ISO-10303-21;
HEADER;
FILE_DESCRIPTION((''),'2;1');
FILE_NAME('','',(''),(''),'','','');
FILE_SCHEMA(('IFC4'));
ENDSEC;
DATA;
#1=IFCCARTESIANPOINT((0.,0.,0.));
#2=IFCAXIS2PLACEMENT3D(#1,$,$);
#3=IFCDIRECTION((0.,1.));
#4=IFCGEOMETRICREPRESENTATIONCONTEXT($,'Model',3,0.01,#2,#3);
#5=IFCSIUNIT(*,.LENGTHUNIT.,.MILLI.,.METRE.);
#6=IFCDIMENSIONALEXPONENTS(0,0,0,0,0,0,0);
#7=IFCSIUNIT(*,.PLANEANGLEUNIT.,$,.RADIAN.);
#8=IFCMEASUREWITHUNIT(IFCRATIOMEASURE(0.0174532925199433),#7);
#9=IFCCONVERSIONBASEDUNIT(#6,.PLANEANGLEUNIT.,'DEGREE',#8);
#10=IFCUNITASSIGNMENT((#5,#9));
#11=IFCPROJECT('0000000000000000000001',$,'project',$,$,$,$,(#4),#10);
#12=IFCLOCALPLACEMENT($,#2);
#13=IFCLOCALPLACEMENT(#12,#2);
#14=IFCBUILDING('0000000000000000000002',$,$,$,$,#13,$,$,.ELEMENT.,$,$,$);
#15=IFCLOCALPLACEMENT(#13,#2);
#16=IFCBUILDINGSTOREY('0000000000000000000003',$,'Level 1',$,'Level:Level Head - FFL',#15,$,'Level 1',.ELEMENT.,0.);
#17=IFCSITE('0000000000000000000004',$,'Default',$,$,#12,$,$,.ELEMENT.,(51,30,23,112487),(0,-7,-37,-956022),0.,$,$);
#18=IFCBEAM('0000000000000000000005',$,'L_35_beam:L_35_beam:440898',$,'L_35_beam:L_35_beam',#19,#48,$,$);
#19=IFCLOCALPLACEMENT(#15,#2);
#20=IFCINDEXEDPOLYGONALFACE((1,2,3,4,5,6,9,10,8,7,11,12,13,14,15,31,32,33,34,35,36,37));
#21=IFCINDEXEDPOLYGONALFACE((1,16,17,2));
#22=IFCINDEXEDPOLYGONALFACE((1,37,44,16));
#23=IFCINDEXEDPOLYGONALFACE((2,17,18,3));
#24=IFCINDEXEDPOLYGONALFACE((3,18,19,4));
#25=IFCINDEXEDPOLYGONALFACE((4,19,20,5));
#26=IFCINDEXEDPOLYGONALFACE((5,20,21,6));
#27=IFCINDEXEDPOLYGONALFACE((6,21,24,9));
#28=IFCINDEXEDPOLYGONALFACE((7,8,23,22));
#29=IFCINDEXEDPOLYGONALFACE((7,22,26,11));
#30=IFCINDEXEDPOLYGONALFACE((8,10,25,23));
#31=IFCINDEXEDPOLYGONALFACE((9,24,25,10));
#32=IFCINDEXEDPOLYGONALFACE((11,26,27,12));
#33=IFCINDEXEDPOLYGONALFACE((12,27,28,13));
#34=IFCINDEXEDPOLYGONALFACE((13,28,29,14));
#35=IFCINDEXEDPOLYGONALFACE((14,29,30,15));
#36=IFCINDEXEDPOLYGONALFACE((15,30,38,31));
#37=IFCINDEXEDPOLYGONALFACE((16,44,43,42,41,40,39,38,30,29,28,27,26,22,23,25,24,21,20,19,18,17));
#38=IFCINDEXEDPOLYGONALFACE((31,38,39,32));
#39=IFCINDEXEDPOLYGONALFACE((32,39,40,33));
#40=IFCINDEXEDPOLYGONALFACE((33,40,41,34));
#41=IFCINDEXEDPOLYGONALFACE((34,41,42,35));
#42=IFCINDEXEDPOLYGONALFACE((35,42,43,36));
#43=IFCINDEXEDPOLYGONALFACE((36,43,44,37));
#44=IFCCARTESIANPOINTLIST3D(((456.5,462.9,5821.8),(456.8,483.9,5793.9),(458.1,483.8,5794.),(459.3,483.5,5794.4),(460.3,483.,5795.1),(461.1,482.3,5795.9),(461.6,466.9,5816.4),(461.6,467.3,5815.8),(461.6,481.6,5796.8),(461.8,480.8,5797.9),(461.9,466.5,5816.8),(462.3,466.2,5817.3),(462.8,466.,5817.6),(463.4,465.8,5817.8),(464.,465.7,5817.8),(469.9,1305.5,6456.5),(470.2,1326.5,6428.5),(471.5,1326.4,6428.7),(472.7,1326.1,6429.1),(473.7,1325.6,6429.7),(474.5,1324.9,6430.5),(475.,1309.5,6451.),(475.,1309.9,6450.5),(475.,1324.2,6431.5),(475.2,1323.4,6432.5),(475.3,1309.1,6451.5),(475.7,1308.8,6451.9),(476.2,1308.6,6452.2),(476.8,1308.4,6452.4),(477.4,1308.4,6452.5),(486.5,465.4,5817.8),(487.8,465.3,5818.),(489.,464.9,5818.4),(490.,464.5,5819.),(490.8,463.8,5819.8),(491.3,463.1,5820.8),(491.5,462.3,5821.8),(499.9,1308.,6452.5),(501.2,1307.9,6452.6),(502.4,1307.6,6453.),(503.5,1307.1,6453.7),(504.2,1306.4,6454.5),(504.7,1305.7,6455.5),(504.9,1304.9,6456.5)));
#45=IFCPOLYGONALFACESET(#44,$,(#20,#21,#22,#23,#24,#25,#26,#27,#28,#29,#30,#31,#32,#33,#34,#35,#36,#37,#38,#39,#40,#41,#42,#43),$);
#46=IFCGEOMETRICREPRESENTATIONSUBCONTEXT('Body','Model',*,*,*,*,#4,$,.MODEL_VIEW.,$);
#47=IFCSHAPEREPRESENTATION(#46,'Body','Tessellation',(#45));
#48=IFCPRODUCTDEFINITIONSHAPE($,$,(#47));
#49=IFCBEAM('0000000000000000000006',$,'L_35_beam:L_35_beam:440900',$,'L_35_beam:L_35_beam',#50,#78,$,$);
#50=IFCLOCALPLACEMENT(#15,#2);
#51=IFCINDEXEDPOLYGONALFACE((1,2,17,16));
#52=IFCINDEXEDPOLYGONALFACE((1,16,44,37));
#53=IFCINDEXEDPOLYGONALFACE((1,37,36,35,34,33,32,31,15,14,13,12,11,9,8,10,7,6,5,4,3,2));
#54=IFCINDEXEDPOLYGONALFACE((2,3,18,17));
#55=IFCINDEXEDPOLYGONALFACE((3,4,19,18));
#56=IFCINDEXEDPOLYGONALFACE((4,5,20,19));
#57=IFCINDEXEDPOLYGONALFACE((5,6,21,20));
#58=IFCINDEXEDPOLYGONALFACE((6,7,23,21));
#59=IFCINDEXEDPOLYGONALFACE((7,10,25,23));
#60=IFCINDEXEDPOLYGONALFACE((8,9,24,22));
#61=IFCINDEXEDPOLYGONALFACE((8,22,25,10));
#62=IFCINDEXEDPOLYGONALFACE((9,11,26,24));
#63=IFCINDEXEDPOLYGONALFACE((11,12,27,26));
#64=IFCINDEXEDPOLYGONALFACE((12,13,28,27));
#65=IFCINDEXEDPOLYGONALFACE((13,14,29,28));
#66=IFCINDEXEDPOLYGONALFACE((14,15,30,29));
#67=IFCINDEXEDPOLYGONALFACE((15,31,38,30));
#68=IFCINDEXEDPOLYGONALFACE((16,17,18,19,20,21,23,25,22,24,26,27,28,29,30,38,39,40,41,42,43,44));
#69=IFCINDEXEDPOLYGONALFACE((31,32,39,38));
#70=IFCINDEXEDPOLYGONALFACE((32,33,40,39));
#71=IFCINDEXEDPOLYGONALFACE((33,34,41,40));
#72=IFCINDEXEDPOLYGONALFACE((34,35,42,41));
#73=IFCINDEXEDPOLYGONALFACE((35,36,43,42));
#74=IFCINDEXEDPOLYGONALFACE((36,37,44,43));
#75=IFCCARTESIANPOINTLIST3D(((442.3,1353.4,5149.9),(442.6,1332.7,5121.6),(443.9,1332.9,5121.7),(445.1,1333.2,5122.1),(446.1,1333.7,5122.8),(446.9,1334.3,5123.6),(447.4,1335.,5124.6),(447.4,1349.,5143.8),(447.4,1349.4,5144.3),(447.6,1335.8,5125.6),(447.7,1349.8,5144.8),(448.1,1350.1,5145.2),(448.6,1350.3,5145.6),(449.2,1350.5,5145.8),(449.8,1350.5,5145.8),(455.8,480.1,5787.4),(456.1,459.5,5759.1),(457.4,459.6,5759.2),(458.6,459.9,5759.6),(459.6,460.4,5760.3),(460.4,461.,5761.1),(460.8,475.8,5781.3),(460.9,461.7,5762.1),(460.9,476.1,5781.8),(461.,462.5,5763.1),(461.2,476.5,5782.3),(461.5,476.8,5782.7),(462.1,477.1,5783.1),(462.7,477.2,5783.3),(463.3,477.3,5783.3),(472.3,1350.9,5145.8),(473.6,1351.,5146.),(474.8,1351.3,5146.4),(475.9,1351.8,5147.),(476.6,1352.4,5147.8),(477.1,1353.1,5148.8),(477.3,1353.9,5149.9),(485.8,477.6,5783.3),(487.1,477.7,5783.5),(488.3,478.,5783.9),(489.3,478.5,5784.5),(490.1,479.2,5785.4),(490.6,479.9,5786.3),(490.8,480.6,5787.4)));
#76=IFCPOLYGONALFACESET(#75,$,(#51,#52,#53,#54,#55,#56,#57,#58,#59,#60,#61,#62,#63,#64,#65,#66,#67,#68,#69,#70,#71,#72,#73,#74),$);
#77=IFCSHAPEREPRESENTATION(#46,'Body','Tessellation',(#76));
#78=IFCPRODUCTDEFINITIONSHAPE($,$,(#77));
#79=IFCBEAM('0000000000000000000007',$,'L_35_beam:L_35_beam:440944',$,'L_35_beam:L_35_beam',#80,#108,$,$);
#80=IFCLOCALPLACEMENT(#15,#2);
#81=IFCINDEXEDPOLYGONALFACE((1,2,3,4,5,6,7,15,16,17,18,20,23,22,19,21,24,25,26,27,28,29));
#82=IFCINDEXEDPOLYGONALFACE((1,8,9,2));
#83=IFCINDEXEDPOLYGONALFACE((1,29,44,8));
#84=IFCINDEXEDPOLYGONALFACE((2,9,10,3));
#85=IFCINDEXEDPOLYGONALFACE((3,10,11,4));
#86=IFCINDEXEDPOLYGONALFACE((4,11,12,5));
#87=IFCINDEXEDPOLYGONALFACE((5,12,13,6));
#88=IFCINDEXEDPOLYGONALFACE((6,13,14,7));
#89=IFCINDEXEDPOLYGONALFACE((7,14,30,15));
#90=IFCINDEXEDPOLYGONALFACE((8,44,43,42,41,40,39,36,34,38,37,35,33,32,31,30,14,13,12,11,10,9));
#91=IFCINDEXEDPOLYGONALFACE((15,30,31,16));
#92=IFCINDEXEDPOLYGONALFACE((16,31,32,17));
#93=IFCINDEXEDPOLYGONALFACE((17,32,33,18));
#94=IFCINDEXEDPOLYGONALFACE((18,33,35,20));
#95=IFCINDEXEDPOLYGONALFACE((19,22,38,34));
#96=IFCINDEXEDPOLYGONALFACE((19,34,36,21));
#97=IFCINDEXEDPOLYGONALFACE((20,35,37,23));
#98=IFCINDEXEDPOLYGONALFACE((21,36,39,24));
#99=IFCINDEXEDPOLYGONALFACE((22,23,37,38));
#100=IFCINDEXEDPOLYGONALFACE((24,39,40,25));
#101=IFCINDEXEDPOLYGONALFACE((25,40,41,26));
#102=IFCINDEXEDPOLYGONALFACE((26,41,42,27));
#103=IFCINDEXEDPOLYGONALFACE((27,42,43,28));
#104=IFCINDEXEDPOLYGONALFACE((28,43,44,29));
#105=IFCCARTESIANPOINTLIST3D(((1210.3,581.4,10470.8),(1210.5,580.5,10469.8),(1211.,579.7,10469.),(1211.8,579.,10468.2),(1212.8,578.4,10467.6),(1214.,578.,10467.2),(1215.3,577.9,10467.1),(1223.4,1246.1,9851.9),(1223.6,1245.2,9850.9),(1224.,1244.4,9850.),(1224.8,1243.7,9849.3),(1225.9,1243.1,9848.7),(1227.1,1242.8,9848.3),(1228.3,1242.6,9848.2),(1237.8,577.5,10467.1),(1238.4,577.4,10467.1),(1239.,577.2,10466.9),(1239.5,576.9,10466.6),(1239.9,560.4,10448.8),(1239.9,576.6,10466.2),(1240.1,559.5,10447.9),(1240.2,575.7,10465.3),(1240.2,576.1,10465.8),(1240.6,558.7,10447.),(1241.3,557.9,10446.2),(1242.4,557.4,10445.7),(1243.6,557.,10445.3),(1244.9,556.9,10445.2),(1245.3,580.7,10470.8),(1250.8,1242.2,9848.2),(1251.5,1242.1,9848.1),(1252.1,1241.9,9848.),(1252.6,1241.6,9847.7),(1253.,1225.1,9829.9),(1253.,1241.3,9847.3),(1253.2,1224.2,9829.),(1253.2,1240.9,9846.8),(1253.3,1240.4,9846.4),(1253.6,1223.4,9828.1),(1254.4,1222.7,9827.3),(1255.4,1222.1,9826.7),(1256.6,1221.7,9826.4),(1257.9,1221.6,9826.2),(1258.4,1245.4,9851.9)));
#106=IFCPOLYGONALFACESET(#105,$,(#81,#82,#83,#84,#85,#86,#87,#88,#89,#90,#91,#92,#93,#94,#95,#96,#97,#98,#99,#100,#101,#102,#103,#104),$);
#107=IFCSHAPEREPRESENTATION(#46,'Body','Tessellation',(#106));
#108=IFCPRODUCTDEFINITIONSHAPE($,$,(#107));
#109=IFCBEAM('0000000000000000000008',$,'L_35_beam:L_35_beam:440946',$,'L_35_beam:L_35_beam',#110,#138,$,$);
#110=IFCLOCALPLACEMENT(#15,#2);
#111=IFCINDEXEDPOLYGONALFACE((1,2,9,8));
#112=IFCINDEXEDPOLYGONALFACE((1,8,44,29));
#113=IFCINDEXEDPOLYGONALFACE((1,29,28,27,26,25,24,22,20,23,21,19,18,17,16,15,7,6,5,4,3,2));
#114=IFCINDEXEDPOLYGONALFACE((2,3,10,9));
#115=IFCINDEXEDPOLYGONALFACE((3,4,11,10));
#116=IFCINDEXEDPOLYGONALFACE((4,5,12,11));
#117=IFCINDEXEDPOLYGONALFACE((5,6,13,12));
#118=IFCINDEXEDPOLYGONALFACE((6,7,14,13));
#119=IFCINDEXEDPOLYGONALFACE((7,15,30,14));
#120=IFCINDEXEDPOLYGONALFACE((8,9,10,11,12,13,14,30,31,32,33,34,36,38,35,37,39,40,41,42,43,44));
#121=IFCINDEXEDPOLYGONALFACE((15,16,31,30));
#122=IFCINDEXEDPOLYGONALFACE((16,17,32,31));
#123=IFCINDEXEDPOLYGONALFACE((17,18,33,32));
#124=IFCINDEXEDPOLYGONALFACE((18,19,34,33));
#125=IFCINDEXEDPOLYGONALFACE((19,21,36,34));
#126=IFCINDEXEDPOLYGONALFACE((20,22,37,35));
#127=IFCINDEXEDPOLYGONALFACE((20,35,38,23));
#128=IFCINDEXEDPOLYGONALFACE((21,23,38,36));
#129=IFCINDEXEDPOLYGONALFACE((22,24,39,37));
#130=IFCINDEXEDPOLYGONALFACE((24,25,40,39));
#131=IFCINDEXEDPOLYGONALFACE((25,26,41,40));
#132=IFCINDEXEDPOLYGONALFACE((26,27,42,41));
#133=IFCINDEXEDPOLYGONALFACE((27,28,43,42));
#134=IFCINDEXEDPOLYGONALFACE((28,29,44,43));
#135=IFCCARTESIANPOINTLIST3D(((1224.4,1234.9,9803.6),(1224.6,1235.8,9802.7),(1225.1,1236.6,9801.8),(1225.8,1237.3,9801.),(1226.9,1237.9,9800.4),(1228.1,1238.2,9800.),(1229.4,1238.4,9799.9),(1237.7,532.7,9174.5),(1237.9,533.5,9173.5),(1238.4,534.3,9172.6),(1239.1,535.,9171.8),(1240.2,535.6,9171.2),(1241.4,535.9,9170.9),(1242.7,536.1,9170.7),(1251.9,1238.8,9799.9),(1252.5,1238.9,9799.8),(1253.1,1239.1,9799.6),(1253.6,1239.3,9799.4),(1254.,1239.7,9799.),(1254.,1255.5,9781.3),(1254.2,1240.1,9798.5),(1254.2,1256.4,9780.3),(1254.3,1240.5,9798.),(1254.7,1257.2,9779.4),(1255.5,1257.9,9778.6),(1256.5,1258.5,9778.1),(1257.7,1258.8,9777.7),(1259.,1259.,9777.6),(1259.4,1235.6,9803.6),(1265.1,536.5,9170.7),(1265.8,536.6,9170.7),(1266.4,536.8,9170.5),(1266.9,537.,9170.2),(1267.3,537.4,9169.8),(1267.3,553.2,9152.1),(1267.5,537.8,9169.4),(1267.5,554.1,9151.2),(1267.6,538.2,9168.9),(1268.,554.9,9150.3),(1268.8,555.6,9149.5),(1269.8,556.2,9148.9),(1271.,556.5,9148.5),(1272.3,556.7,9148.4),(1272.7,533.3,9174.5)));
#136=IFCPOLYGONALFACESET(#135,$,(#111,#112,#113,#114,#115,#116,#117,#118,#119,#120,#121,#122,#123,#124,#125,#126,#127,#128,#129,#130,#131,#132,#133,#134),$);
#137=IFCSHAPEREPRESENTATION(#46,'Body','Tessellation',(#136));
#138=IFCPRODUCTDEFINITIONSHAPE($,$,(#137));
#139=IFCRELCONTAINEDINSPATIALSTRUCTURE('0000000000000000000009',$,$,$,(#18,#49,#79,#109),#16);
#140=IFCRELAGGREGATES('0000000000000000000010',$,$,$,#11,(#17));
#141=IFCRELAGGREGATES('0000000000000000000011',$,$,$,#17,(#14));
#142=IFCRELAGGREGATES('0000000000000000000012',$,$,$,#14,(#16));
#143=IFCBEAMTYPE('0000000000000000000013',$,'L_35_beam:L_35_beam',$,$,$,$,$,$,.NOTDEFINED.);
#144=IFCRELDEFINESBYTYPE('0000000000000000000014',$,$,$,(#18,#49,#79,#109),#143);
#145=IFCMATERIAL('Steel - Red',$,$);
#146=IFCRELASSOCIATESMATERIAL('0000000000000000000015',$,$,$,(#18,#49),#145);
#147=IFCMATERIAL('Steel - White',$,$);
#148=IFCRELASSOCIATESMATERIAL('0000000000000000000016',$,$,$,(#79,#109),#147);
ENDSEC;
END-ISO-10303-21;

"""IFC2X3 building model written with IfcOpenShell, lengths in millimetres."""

from ifc_helpers import new_model, entity, si_unit, converted_unit, direction, frame, frame_2d, origin, place, context, subcontext, project, spatial, polyline, circle_curve, parameter, trimmed, segment, composite_curve, outline, extrude, material, type_object, element, save


model = new_model("IFC2X3")

# Units and contexts
model_context = context("Model", 3, precision=0.01, world=origin(), true_north=direction((0.0, 1.0)))
body_context = subcontext(model_context, "Body", "Model", "MODEL_VIEW")
ifc_project = project(units=[si_unit("LENGTHUNIT", "METRE", prefix="MILLI"), converted_unit("PLANEANGLEUNIT", "DEGREE", entity("IfcRatioMeasure", 0.0174532925199433), si_unit("PLANEANGLEUNIT", "RADIAN"), dimensions=[0, 0, 0, 0, 0, 0, 0])], contexts=[model_context])

# Site, building, storey
site_placement = place(None, origin())
site = spatial("IfcSite", under=ifc_project, at=site_placement, Name="Default", CompositionType="ELEMENT", RefLatitude=(51, 30, 23, 112487), RefLongitude=(0, -7, -37, -956022), RefElevation=0.0)
building_placement = place(site_placement, origin())
building = spatial("IfcBuilding", under=site, at=building_placement, CompositionType="ELEMENT")
storey_placement = place(building_placement, origin())
storey = spatial("IfcBuildingStorey", under=building, at=storey_placement, Name="Level 1", ObjectType="Level:Level Head - FFL", LongName="Level 1", CompositionType="ELEMENT", Elevation=0.0)

# Beams
ifc_material_1 = material(Name="Steel - Red")
ifc_material_2 = material(Name="Steel - White")
beam_type_1 = type_object("IfcBeamType", Name="L_35_beam:L_35_beam", PredefinedType="NOTDEFINED")
beam_1_placement = place(storey_placement, frame((448.3, 448.3, 5788.9), z_axis=(-0.009573, -0.601513, 0.798806), x_axis=(0.012712, 0.798705, 0.601589)))
element("IfcBeam", 1, at=beam_1_placement, inside=storey, type_object=beam_type_1, material=ifc_material_1, Name="L_35_beam:L_35_beam:440898", ObjectType="L_35_beam:L_35_beam", context=body_context, shape_type="SweptSolid", body=[
    extrude(outline(composite_curve([segment(polyline([(-23.2, -11.8), (11.8, -11.8)]), True, "CONTINUOUS"), segment(polyline([(11.8, -11.8), (11.8, 23.2)]), True, "CONTINUOUS"), segment(trimmed(circle_curve(frame_2d((11.8, 18.2), x_axis=(0.0, 1.0)), 5.0), [parameter(0.0)], [parameter(90.0)], True, "PARAMETER"), True, "CONTINUOUS"), segment(polyline([(6.8, 18.2), (6.8, -4.3)]), True, "CONTINUOUS"), segment(trimmed(circle_curve(frame_2d((4.3, -4.3), x_axis=(1.0, 0.0)), 2.5), [parameter(270.0)], [parameter(0.0)], True, "PARAMETER"), False, "CONTINUOUS"), segment(polyline([(4.3, -6.8), (-18.2, -6.8)]), True, "CONTINUOUS"), segment(trimmed(circle_curve(frame_2d((-18.2, -11.8), x_axis=(0.0, 1.0)), 5.0), [parameter(0.0)], [parameter(90.0)], True, "PARAMETER"), True, "CONTINUOUS")], self_intersect=False)), frame((31.6, -19.8, 5.7), z_axis=(1.0, 0.0, 0.0), x_axis=(0.0, 0.0, 1.0)), (0.0, 0.0, 1.0), 1055.0),
])
beam_2_placement = place(storey_placement, frame((448.2, 448.3, 5788.8), z_axis=(-0.009093, 0.589511, 0.807709), x_axis=(-0.012457, 0.807613, -0.589581)))
element("IfcBeam", 2, at=beam_2_placement, inside=storey, type_object=beam_type_1, material=ifc_material_1, Name="L_35_beam:L_35_beam:440900", ObjectType="L_35_beam:L_35_beam", context=body_context, shape_type="SweptSolid", body=[
    extrude(outline(composite_curve([segment(polyline([(-23.2, -11.8), (11.8, -11.8)]), True, "CONTINUOUS"), segment(polyline([(11.8, -11.8), (11.8, 23.2)]), True, "CONTINUOUS"), segment(trimmed(circle_curve(frame_2d((11.8, 18.2), x_axis=(0.0, 1.0)), 5.0), [parameter(0.0)], [parameter(90.0)], True, "PARAMETER"), True, "CONTINUOUS"), segment(polyline([(6.8, 18.2), (6.8, -4.3)]), True, "CONTINUOUS"), segment(trimmed(circle_curve(frame_2d((4.3, -4.3), x_axis=(1.0, 0.0)), 2.5), [parameter(270.0)], [parameter(0.0)], True, "PARAMETER"), False, "CONTINUOUS"), segment(polyline([(4.3, -6.8), (-18.2, -6.8)]), True, "CONTINUOUS"), segment(trimmed(circle_curve(frame_2d((-18.2, -11.8), x_axis=(0.0, 1.0)), 5.0), [parameter(0.0)], [parameter(90.0)], True, "PARAMETER"), True, "CONTINUOUS")], self_intersect=False)), frame((26.5, -19.8, 5.7), z_axis=(1.0, 0.0, 0.0), x_axis=(0.0, 0.0, 1.0)), (0.0, 0.0, 1.0), 1081.3),
])
beam_3_placement = place(storey_placement, frame((1266.8, 1266.8, 9807.9), z_axis=(0.013403, 0.681245, 0.731933), x_axis=(-0.014397, -0.731791, 0.681377)))
element("IfcBeam", 3, at=beam_3_placement, inside=storey, type_object=beam_type_1, material=ifc_material_2, Name="L_35_beam:L_35_beam:440944", ObjectType="L_35_beam:L_35_beam", context=body_context, shape_type="SweptSolid", body=[
    extrude(outline(composite_curve([segment(polyline([(-23.2, -11.8), (11.8, -11.8)]), True, "CONTINUOUS"), segment(polyline([(11.8, -11.8), (11.8, 23.2)]), True, "CONTINUOUS"), segment(trimmed(circle_curve(frame_2d((11.8, 18.2), x_axis=(0.0, 1.0)), 5.0), [parameter(0.0)], [parameter(90.0)], True, "PARAMETER"), True, "CONTINUOUS"), segment(polyline([(6.8, 18.2), (6.8, -4.3)]), True, "CONTINUOUS"), segment(trimmed(circle_curve(frame_2d((4.3, -4.3), x_axis=(1.0, 0.0)), 2.5), [parameter(270.0)], [parameter(0.0)], True, "PARAMETER"), False, "CONTINUOUS"), segment(polyline([(4.3, -6.8), (-18.2, -6.8)]), True, "CONTINUOUS"), segment(trimmed(circle_curve(frame_2d((-18.2, -11.8), x_axis=(0.0, 1.0)), 5.0), [parameter(0.0)], [parameter(90.0)], True, "PARAMETER"), True, "CONTINUOUS")], self_intersect=False)), frame((45.7, -19.8, 5.7), z_axis=(1.0, 0.0, 0.0), x_axis=(0.0, 0.0, 1.0)), (0.0, 0.0, 1.0), 908.3),
])
beam_4_placement = place(storey_placement, frame((1266.8, 1266.8, 9807.9), z_axis=(0.012627, -0.66707, 0.744888), x_axis=(0.014097, -0.744755, -0.667189)))
element("IfcBeam", 4, at=beam_4_placement, inside=storey, type_object=beam_type_1, material=ifc_material_2, Name="L_35_beam:L_35_beam:440946", ObjectType="L_35_beam:L_35_beam", context=body_context, shape_type="SweptSolid", body=[
    extrude(outline(composite_curve([segment(polyline([(-23.2, -11.8), (11.8, -11.8)]), True, "CONTINUOUS"), segment(polyline([(11.8, -11.8), (11.8, 23.2)]), True, "CONTINUOUS"), segment(trimmed(circle_curve(frame_2d((11.8, 18.2), x_axis=(0.0, 1.0)), 5.0), [parameter(0.0)], [parameter(90.0)], True, "PARAMETER"), True, "CONTINUOUS"), segment(polyline([(6.8, 18.2), (6.8, -4.3)]), True, "CONTINUOUS"), segment(trimmed(circle_curve(frame_2d((4.3, -4.3), x_axis=(1.0, 0.0)), 2.5), [parameter(270.0)], [parameter(0.0)], True, "PARAMETER"), False, "CONTINUOUS"), segment(polyline([(4.3, -6.8), (-18.2, -6.8)]), True, "CONTINUOUS"), segment(trimmed(circle_curve(frame_2d((-18.2, -11.8), x_axis=(0.0, 1.0)), 5.0), [parameter(0.0)], [parameter(90.0)], True, "PARAMETER"), True, "CONTINUOUS")], self_intersect=False)), frame((26.0, -19.8, 5.7), z_axis=(1.0, 0.0, 0.0), x_axis=(0.0, 0.0, 1.0)), (0.0, 0.0, 1.0), 943.0),
])

save(model, "model.ifc")
